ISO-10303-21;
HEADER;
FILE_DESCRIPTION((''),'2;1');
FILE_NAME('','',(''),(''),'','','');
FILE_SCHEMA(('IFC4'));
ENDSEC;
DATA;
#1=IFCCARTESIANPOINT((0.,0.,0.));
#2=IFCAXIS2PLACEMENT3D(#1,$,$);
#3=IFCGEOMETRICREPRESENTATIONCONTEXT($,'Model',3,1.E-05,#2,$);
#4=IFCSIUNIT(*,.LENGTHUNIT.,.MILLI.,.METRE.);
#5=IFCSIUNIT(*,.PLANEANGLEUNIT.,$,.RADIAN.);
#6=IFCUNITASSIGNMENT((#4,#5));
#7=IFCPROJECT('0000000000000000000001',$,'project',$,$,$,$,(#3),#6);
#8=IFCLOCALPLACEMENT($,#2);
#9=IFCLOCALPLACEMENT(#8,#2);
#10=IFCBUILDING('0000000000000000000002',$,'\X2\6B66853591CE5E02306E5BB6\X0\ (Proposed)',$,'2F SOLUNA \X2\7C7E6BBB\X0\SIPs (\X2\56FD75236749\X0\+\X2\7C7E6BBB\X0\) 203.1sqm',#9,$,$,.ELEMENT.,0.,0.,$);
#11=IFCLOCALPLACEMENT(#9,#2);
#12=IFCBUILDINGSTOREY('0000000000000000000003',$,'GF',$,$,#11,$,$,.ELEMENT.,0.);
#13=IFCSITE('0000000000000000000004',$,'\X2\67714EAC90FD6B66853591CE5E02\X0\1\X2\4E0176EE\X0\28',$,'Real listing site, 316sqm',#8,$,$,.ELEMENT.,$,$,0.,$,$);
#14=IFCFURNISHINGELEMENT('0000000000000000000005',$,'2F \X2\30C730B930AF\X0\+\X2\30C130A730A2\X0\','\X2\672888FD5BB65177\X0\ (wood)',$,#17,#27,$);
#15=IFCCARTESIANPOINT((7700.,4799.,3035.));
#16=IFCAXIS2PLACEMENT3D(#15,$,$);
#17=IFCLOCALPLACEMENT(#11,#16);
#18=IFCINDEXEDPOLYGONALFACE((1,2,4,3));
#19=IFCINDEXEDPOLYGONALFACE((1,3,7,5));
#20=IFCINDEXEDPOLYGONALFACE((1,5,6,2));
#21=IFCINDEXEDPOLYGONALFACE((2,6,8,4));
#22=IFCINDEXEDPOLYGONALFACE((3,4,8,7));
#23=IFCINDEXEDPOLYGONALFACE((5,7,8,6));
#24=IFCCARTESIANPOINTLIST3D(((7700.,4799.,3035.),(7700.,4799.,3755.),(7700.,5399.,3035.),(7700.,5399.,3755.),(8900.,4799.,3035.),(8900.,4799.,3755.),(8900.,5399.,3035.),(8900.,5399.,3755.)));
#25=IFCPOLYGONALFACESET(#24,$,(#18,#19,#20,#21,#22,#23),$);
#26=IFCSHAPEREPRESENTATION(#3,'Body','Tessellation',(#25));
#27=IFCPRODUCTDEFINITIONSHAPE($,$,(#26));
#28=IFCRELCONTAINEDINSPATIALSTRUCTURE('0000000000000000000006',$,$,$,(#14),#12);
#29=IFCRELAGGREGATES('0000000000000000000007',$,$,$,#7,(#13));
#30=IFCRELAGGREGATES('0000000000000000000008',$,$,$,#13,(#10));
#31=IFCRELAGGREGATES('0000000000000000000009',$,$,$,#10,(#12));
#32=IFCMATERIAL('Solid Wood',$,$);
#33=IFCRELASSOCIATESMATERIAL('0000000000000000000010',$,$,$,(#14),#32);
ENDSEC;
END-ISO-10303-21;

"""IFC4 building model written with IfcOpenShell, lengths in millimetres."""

from ifc_helpers import new_model, si_unit, frame, frame_2d, origin, place, context, project, spatial, rectangle, extrude, material, element, save


model = new_model("IFC4")

# Units and contexts
model_context = context("Model", 3, precision=1e-05, world=origin())
ifc_project = project(units=[si_unit("LENGTHUNIT", "METRE", prefix="MILLI"), si_unit("PLANEANGLEUNIT", "RADIAN")], contexts=[model_context])

# Site, building, storey
site_placement = place(None, origin())
site = spatial("IfcSite", under=ifc_project, at=site_placement, Name="東京都武蔵野市1丁目28", ObjectType="Real listing site, 316sqm", CompositionType="ELEMENT", RefElevation=0.0)
building_placement = place(site_placement, origin())
building = spatial("IfcBuilding", under=site, at=building_placement, Name="武蔵野市の家 (Proposed)", ObjectType="2F SOLUNA 籾殻SIPs (国産杉+籾殻) 203.1sqm", CompositionType="ELEMENT", ElevationOfRefHeight=0.0, ElevationOfTerrain=0.0)
storey_placement = place(building_placement, origin())
storey = spatial("IfcBuildingStorey", under=building, at=storey_placement, Name="GF", CompositionType="ELEMENT", Elevation=0.0)

# Shared definitions
ifc_material_1 = material(Name="Solid Wood")

# Furnishing element
furnishing_1_placement = place(storey_placement, frame((7700.0, 4799.0, 3035.0)))
element("IfcFurnishingElement", 1, at=furnishing_1_placement, inside=storey, material=ifc_material_1, Name="2F デスク+チェア", Description="木製家具 (wood)", context=model_context, shape_type="SweptSolid", body=[
    extrude(rectangle(XDim=1200.0, YDim=600.0, at=frame_2d((600.0, 300.0))), frame((7700.0, 4799.0, 3035.0)), (0.0, 0.0, 1.0), 720.0),
])

save(model, "model.ifc")
